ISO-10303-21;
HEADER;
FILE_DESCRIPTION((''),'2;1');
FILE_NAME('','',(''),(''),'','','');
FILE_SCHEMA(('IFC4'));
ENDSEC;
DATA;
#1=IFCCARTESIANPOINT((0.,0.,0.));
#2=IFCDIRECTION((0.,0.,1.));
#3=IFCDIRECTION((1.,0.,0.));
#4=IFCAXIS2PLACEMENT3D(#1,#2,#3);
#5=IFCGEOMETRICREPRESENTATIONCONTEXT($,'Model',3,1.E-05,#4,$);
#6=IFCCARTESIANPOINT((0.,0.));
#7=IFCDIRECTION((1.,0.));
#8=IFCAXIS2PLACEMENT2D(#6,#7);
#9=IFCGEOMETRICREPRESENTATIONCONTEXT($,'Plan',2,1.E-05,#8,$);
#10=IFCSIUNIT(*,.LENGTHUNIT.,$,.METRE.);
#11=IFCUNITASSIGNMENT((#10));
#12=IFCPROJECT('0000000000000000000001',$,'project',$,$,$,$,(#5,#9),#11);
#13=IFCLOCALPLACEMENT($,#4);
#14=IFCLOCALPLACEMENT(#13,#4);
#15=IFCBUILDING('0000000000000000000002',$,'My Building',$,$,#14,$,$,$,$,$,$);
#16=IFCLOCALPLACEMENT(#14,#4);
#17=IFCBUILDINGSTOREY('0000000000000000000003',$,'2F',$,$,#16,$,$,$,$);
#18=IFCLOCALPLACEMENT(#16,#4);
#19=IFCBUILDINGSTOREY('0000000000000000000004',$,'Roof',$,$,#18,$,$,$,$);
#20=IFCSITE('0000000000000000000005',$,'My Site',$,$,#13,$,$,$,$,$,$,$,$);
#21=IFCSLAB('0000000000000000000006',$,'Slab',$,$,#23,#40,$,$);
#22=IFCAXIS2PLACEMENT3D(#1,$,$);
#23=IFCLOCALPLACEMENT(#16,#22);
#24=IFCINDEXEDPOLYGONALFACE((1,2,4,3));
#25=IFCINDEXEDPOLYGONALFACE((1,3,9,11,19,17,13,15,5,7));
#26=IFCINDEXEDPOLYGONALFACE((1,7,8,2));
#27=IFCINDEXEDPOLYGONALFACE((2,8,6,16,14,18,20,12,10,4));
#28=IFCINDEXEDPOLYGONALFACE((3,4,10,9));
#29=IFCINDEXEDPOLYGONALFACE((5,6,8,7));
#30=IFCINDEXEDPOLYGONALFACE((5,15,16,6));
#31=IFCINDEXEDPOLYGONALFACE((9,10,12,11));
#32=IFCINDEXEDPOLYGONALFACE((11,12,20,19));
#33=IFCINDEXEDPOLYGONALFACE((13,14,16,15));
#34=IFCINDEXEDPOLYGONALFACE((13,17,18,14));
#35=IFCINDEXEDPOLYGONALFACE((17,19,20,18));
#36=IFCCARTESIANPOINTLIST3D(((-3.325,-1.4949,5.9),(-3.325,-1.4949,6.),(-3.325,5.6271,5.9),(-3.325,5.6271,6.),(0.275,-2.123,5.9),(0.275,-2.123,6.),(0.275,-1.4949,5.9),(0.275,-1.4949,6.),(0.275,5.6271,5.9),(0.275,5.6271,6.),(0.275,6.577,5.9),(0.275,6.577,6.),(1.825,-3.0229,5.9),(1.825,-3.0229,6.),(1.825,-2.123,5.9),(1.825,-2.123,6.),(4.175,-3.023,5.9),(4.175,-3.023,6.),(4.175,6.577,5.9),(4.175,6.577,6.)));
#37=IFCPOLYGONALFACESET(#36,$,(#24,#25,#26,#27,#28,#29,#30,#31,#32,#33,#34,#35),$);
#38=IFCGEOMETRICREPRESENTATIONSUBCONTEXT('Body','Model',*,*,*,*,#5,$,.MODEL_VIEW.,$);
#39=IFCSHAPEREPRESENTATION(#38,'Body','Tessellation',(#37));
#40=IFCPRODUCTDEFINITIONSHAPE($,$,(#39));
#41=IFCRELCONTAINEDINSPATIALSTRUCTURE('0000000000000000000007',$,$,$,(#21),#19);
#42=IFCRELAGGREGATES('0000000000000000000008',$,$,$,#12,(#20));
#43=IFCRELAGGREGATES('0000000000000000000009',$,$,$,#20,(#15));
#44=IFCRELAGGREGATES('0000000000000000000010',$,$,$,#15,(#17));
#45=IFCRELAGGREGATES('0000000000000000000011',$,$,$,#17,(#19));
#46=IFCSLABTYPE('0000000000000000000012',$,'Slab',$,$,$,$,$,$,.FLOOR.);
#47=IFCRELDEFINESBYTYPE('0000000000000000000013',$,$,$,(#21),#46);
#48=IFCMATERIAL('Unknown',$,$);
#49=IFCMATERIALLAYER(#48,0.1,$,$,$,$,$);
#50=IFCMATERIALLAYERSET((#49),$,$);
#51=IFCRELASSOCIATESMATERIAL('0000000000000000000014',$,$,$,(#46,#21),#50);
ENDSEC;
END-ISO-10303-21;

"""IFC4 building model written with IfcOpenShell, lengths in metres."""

from ifc_helpers import new_model, si_unit, frame, origin_with_axes, origin_2d_with_axis, place, context, subcontext, project, spatial, indexed_curve, outline, extrude, material, layer, layer_set, layer_usage, type_object, element, save


model = new_model("IFC4")

# Units and contexts
model_context = context("Model", 3, precision=1e-05, world=origin_with_axes())
plan_context = context("Plan", 2, precision=1e-05, world=origin_2d_with_axis())
body_context = subcontext(model_context, "Body", "Model", "MODEL_VIEW")
ifc_project = project(units=[si_unit("LENGTHUNIT", "METRE")], contexts=[model_context, plan_context])

# Site, building, storeys
site_placement = place(None, origin_with_axes())
site = spatial("IfcSite", under=ifc_project, at=site_placement, Name="My Site")
building_placement = place(site_placement, origin_with_axes())
building = spatial("IfcBuilding", under=site, at=building_placement, Name="My Building")
storey_1_placement = place(building_placement, origin_with_axes())
storey_1 = spatial("IfcBuildingStorey", under=building, at=storey_1_placement, Name="2F")
storey_2_placement = place(storey_1_placement, origin_with_axes())
storey_2 = spatial("IfcBuildingStorey", under=storey_1, at=storey_2_placement, Name="Roof")

# Slab
ifc_material = material(Name="Unknown")
ifc_layer = layer(ifc_material, 0.1)
ifc_layer_set = layer_set([ifc_layer])
ifc_layer_usage = layer_usage(ifc_layer_set, "AXIS3", "POSITIVE", -0.1)
slab_type = type_object("IfcSlabType", Name="Slab", PredefinedType="FLOOR", material=ifc_layer_set)
slab_placement = place(storey_2_placement, frame((4.175, -3.023, 6.0), z_axis=(0.0, 0.0, 1.0), x_axis=(1.0, 0.0, 0.0)))
element("IfcSlab", 1, at=slab_placement, inside=storey_2, type_object=slab_type, material=ifc_layer_usage, Name="Slab", context=body_context, shape_type="SweptSolid", body=[
    extrude(outline(indexed_curve([(0.0, 0.0), (0.0, 9.6), (-3.9, 9.6), (-3.9, 8.65), (-7.5, 8.65), (-7.5, 1.5281), (-3.9, 1.5281), (-3.9, 0.9), (-2.35, 0.9), (-2.35, 0.0001), (0.0, 0.0)])), frame((0.0, 0.0, -0.1), z_axis=(0.0, 0.0, 1.0), x_axis=(1.0, 0.0, 0.0)), (0.0, 0.0, 1.0), 0.1),
])

save(model, "model.ifc")
